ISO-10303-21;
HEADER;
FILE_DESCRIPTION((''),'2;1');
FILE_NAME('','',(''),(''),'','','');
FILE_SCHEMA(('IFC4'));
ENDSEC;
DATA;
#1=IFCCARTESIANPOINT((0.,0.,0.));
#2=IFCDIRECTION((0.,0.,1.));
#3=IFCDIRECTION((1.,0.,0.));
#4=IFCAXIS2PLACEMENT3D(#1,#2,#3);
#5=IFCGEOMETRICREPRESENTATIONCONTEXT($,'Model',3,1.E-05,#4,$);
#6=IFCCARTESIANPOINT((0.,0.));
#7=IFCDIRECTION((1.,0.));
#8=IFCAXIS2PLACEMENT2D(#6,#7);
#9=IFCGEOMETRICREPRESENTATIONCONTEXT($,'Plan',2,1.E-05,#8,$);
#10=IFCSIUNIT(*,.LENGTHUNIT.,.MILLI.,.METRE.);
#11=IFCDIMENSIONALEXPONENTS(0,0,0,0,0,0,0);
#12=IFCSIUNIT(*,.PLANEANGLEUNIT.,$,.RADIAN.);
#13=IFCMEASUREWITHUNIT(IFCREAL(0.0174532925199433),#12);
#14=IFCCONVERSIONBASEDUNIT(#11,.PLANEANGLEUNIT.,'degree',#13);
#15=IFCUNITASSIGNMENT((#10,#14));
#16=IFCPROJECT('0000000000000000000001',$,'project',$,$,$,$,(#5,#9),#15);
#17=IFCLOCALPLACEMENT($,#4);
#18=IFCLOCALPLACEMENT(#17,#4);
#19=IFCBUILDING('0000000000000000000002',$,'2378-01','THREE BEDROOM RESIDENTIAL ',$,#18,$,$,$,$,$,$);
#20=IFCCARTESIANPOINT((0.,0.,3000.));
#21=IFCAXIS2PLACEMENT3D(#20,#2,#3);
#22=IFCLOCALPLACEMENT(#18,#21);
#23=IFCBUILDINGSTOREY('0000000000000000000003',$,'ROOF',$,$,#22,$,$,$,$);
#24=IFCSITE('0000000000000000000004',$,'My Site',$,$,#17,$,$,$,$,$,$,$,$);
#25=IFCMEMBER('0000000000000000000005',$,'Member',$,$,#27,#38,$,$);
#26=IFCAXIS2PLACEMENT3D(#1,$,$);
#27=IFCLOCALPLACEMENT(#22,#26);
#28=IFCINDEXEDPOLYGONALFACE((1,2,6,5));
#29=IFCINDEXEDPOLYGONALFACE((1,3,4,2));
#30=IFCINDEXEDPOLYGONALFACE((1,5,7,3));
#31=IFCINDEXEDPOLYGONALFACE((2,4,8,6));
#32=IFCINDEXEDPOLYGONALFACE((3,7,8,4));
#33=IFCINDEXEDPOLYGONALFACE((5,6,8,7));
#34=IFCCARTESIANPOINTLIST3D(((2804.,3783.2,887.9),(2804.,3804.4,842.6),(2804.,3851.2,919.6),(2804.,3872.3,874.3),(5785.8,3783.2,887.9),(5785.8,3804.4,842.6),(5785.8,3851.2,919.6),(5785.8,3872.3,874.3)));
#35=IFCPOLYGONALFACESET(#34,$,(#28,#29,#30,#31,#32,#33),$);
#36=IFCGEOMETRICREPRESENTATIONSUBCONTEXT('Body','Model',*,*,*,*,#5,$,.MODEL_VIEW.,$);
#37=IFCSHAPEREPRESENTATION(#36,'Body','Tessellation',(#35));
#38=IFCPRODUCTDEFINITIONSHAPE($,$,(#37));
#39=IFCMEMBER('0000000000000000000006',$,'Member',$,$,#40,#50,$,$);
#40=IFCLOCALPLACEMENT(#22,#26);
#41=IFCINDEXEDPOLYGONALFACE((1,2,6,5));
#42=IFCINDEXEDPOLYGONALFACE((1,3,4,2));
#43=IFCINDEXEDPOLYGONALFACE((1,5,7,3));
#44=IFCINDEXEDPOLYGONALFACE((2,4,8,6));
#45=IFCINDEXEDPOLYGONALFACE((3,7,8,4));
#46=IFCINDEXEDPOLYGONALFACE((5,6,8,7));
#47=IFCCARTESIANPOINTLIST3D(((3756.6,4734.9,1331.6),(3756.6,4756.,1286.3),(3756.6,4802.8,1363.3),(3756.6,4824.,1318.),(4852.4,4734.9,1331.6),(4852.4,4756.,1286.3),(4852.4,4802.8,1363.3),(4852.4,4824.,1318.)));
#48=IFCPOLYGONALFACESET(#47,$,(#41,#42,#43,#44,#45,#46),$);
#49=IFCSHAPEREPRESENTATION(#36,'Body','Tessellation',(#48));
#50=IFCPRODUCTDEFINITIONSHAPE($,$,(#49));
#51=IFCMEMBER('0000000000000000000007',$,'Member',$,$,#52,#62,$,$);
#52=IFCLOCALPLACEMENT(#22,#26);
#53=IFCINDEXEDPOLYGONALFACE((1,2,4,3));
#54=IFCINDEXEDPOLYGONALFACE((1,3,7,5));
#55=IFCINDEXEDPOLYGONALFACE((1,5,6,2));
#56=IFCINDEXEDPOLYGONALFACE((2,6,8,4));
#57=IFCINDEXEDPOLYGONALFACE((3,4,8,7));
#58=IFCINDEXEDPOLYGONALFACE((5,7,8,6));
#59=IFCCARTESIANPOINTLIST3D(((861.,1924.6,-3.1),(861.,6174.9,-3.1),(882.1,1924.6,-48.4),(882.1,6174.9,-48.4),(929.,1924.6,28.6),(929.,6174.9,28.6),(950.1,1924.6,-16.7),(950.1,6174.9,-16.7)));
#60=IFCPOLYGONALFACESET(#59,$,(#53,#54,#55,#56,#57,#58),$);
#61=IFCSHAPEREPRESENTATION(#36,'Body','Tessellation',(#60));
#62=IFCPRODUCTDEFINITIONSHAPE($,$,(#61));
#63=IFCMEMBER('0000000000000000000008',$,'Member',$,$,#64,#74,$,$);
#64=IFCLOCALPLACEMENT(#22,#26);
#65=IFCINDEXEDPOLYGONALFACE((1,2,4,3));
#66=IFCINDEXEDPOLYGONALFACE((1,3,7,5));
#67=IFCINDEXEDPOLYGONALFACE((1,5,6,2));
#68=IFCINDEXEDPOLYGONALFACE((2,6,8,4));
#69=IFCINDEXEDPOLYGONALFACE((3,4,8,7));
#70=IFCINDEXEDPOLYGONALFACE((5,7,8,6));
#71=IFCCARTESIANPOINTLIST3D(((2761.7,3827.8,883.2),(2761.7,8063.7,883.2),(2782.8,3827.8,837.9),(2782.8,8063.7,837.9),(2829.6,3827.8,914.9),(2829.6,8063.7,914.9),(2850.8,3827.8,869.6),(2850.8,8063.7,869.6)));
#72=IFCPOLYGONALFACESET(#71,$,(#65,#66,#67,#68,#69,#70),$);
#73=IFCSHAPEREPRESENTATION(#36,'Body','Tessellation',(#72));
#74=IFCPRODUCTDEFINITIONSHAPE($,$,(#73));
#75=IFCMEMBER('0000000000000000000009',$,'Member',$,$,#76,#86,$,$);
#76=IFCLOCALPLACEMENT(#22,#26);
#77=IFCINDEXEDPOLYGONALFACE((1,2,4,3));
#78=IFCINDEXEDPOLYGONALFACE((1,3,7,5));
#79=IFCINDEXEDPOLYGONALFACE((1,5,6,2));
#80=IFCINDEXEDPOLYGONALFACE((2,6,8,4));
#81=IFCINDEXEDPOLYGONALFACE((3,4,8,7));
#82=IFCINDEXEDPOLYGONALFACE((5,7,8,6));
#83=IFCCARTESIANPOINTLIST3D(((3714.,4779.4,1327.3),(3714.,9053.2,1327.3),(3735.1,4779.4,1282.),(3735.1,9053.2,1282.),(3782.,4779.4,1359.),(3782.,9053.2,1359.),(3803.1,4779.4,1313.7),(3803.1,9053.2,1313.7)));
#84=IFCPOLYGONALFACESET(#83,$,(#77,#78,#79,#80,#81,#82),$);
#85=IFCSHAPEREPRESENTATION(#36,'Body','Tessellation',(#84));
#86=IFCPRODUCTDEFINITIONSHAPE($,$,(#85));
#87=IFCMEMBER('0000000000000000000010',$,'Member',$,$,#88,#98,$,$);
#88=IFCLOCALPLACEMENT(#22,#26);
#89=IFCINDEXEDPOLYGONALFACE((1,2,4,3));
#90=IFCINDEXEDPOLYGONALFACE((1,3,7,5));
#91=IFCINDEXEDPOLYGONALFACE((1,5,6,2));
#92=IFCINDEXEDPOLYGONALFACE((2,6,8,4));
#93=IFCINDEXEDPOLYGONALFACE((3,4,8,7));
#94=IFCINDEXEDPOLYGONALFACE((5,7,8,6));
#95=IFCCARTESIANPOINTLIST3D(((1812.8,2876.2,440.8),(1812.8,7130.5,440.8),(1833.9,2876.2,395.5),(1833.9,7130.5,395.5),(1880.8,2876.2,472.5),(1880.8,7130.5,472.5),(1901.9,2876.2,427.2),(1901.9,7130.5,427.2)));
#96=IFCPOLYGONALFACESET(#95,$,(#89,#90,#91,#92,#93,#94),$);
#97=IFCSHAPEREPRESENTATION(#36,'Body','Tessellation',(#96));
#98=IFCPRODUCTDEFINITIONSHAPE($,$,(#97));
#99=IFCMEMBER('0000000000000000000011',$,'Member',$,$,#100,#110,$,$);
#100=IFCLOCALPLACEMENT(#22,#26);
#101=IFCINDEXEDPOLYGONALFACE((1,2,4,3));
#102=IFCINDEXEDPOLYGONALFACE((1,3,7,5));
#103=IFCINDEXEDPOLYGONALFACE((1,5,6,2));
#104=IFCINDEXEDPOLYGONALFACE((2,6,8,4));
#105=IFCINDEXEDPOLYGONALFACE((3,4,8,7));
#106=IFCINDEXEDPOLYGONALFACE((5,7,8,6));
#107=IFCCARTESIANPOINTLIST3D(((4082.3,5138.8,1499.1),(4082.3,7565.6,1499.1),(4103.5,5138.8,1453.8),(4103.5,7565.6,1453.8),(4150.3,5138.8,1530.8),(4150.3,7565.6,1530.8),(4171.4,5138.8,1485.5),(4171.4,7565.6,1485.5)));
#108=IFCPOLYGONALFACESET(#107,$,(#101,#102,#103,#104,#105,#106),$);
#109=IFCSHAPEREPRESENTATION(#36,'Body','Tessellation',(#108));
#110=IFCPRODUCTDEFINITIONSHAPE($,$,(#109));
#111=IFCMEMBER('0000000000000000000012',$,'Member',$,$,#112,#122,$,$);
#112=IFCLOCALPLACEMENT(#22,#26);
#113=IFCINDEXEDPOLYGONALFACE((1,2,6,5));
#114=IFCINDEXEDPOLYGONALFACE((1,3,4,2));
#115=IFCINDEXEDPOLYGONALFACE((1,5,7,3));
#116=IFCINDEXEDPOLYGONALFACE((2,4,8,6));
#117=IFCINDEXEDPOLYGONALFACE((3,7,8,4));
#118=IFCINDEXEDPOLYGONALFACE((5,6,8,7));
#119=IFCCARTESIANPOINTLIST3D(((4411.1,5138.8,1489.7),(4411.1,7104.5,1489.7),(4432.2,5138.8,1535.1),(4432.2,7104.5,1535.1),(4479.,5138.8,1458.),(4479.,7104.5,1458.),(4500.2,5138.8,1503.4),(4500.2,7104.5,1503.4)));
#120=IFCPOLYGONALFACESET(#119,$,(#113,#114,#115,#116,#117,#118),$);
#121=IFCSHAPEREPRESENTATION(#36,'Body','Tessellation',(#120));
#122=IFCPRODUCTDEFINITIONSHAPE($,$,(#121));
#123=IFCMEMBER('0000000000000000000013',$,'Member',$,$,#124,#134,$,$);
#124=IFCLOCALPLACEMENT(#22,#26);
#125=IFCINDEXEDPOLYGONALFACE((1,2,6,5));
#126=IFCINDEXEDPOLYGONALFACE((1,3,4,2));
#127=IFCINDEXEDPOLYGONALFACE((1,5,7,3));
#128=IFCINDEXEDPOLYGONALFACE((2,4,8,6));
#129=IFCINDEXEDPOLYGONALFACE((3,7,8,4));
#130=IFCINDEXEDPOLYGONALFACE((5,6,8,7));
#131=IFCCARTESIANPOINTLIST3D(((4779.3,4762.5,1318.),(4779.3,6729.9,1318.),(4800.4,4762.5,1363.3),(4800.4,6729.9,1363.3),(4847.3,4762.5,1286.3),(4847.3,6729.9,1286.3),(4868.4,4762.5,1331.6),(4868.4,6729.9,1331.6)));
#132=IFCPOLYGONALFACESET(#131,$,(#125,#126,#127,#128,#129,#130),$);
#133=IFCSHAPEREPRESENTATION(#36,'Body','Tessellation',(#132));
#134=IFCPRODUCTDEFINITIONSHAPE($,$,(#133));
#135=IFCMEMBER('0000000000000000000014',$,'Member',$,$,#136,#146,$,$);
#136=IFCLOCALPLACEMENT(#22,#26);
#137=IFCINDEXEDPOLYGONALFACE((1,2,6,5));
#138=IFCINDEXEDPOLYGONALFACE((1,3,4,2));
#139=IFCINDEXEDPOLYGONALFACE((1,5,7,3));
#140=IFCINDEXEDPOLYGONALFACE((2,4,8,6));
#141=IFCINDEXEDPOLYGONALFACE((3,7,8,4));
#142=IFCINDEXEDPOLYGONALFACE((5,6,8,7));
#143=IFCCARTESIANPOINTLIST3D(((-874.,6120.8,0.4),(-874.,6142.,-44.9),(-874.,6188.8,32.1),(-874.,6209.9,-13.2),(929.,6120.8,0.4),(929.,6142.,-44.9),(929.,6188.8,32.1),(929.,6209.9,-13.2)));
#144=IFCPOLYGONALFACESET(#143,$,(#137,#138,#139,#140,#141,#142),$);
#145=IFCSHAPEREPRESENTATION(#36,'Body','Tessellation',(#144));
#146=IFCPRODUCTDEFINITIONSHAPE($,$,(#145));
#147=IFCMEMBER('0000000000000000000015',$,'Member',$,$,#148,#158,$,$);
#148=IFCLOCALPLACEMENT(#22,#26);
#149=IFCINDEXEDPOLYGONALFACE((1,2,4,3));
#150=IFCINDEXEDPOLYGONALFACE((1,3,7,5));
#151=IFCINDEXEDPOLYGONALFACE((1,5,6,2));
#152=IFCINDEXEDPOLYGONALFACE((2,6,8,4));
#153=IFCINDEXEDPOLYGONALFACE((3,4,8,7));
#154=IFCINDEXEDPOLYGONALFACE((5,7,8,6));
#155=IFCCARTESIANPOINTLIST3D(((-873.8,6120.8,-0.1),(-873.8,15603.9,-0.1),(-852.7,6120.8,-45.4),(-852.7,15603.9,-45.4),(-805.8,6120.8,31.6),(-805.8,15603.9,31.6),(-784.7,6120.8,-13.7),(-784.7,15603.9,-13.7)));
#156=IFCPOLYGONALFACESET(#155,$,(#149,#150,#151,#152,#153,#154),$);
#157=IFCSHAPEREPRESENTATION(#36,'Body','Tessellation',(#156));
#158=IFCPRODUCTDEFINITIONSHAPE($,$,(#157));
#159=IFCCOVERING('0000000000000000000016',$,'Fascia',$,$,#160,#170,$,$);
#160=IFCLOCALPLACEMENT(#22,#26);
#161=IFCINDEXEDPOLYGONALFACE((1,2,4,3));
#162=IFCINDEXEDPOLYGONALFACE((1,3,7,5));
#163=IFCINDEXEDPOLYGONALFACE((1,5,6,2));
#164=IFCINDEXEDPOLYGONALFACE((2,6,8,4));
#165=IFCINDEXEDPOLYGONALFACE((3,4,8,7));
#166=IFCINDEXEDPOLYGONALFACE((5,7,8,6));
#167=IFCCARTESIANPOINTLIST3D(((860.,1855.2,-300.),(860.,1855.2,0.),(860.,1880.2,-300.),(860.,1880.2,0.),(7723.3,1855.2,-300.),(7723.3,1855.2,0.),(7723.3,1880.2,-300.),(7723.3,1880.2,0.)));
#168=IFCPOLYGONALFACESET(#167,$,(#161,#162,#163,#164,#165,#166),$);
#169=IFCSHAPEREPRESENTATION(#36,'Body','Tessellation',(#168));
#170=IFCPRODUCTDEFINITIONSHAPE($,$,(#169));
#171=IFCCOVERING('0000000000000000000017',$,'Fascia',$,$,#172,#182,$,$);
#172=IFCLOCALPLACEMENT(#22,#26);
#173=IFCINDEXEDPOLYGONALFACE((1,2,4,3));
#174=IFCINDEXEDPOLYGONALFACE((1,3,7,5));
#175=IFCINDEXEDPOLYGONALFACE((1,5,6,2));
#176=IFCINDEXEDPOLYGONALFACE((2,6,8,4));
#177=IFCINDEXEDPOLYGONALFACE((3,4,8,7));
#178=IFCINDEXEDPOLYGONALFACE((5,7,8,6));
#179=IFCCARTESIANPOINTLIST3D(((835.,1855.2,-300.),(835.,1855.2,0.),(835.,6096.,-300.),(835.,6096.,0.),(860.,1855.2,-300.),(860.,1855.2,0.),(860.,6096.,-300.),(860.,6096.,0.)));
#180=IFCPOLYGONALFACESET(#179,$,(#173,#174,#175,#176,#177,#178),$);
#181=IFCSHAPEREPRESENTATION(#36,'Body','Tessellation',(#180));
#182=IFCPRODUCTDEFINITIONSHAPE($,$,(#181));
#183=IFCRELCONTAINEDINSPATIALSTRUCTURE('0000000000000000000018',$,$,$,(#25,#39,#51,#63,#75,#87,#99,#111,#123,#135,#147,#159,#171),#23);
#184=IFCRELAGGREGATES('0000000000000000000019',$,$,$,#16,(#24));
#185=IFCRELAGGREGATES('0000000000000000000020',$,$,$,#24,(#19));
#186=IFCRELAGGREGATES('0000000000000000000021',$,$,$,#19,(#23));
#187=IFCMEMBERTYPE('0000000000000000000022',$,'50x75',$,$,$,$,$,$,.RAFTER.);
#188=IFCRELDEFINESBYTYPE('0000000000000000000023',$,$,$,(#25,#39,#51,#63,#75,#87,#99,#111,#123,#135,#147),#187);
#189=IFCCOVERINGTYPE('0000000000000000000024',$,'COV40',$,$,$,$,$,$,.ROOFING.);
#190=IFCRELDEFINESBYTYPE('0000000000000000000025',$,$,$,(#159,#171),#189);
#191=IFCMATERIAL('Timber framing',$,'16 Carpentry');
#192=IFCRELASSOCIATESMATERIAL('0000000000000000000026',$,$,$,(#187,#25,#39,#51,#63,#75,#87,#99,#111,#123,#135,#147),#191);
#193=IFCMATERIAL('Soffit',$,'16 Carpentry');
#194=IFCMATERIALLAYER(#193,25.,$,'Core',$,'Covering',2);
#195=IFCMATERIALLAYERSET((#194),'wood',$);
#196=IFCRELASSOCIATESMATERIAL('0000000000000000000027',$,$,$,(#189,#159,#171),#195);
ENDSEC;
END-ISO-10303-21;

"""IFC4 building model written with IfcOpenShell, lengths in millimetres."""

from ifc_helpers import new_model, entity, si_unit, converted_unit, frame, origin_with_axes, origin_2d_with_axis, place, context, subcontext, project, spatial, indexed_curve, rectangle, outline, extrude, material, layer, layer_set, layer_usage, material_profile, profile_set, profile_usage, type_object, element, save


model = new_model("IFC4")

# Units and contexts
model_context = context("Model", 3, precision=1e-05, world=origin_with_axes())
plan_context = context("Plan", 2, precision=1e-05, world=origin_2d_with_axis())
body_context = subcontext(model_context, "Body", "Model", "MODEL_VIEW")
ifc_project = project(units=[si_unit("LENGTHUNIT", "METRE", prefix="MILLI"), converted_unit("PLANEANGLEUNIT", "degree", entity("IfcReal", 0.0174532925199433), si_unit("PLANEANGLEUNIT", "RADIAN"), dimensions=[0, 0, 0, 0, 0, 0, 0])], contexts=[model_context, plan_context])

# Site, building, storey
site_placement = place(None, origin_with_axes())
site = spatial("IfcSite", under=ifc_project, at=site_placement, Name="My Site")
building_placement = place(site_placement, origin_with_axes())
building = spatial("IfcBuilding", under=site, at=building_placement, Name="2378-01", Description="THREE BEDROOM RESIDENTIAL ")
storey_placement = place(building_placement, frame((0.0, 0.0, 3000.0), z_axis=(0.0, 0.0, 1.0), x_axis=(1.0, 0.0, 0.0)))
storey = spatial("IfcBuildingStorey", under=building, at=storey_placement, Name="ROOF")

# Members
ifc_material_1 = material(Name="Timber framing", Category="16 Carpentry")
ifc_material_profile_1 = material_profile(ifc_material_1, rectangle(XDim=50.0, YDim=75.0), Name="Lumber2", Category="Substrate", Priority=2)
ifc_profile_set_1 = profile_set([ifc_material_profile_1])
member_type_1 = type_object("IfcMemberType", Name="50x75", PredefinedType="RAFTER", material=ifc_profile_set_1)
ifc_profile_usage_1 = profile_usage(ifc_profile_set_1, cardinal=5)
member_1_placement = place(storey_placement, frame((2804.0, 3827.8, 881.1), z_axis=(1.0, 0.0, 0.0), x_axis=(0.0, 0.422618, -0.906308)))
element("IfcMember", 1, at=member_1_placement, inside=storey, type_object=member_type_1, material=ifc_profile_usage_1, Name="Member", context=body_context, shape_type="SweptSolid", body=[
    extrude(rectangle(XDim=50.0, YDim=75.0), origin_with_axes(), (0.0, 0.0, 1.0), 2981.8),
])
ifc_profile_usage_2 = profile_usage(ifc_profile_set_1, cardinal=5)
member_2_placement = place(storey_placement, frame((3756.6, 4779.4, 1324.8), z_axis=(1.0, 0.0, 0.0), x_axis=(0.0, 0.422618, -0.906308)))
element("IfcMember", 2, at=member_2_placement, inside=storey, type_object=member_type_1, material=ifc_profile_usage_2, Name="Member", context=body_context, shape_type="SweptSolid", body=[
    extrude(rectangle(XDim=50.0, YDim=75.0), origin_with_axes(), (0.0, 0.0, 1.0), 1095.8),
])
ifc_profile_usage_3 = profile_usage(ifc_profile_set_1, cardinal=5)
member_3_placement = place(storey_placement, frame((905.6, 1924.6, -9.9), z_axis=(0.0, 1.0, 0.0), x_axis=(-0.422618, 0.0, 0.906308)))
element("IfcMember", 3, at=member_3_placement, inside=storey, type_object=member_type_1, material=ifc_profile_usage_3, Name="Member", context=body_context, shape_type="SweptSolid", body=[
    extrude(rectangle(XDim=50.0, YDim=75.0), origin_with_axes(), (0.0, 0.0, 1.0), 4250.4),
])
ifc_profile_usage_4 = profile_usage(ifc_profile_set_1, cardinal=5)
member_4_placement = place(storey_placement, frame((2806.2, 3827.8, 876.4), z_axis=(0.0, 1.0, 0.0), x_axis=(-0.422618, 0.0, 0.906308)))
element("IfcMember", 4, at=member_4_placement, inside=storey, type_object=member_type_1, material=ifc_profile_usage_4, Name="Member", context=body_context, shape_type="SweptSolid", body=[
    extrude(rectangle(XDim=50.0, YDim=75.0), origin_with_axes(), (0.0, 0.0, 1.0), 4235.9),
])
ifc_profile_usage_5 = profile_usage(ifc_profile_set_1, cardinal=5)
member_5_placement = place(storey_placement, frame((3758.6, 4779.4, 1320.5), z_axis=(0.0, 1.0, 0.0), x_axis=(-0.422618, 0.0, 0.906308)))
element("IfcMember", 5, at=member_5_placement, inside=storey, type_object=member_type_1, material=ifc_profile_usage_5, Name="Member", context=body_context, shape_type="SweptSolid", body=[
    extrude(rectangle(XDim=50.0, YDim=75.0), origin_with_axes(), (0.0, 0.0, 1.0), 4273.8),
])
ifc_profile_usage_6 = profile_usage(ifc_profile_set_1, cardinal=5)
member_6_placement = place(storey_placement, frame((1857.4, 2876.2, 434.0), z_axis=(0.0, 1.0, 0.0), x_axis=(-0.422618, 0.0, 0.906308)))
element("IfcMember", 6, at=member_6_placement, inside=storey, type_object=member_type_1, material=ifc_profile_usage_6, Name="Member", context=body_context, shape_type="SweptSolid", body=[
    extrude(rectangle(XDim=50.0, YDim=75.0), origin_with_axes(), (0.0, 0.0, 1.0), 4254.3),
])
ifc_profile_usage_7 = profile_usage(ifc_profile_set_1, cardinal=5)
member_7_placement = place(storey_placement, frame((4126.9, 5138.8, 1492.3), z_axis=(0.0, 1.0, 0.0), x_axis=(-0.422618, 0.0, 0.906308)))
element("IfcMember", 7, at=member_7_placement, inside=storey, type_object=member_type_1, material=ifc_profile_usage_7, Name="Member", context=body_context, shape_type="SweptSolid", body=[
    extrude(rectangle(XDim=50.0, YDim=75.0), origin_with_axes(), (0.0, 0.0, 1.0), 2426.8),
])
ifc_profile_usage_8 = profile_usage(ifc_profile_set_1, cardinal=5)
member_8_placement = place(storey_placement, frame((4455.6, 5138.8, 1496.5), z_axis=(0.0, 1.0, 0.0), x_axis=(-0.422618, 0.0, -0.906308)))
element("IfcMember", 8, at=member_8_placement, inside=storey, type_object=member_type_1, material=ifc_profile_usage_8, Name="Member", context=body_context, shape_type="SweptSolid", body=[
    extrude(rectangle(XDim=50.0, YDim=75.0), origin_with_axes(), (0.0, 0.0, 1.0), 1965.7),
])
ifc_profile_usage_9 = profile_usage(ifc_profile_set_1, cardinal=5)
member_9_placement = place(storey_placement, frame((4823.8, 4762.5, 1324.8), z_axis=(0.0, 1.0, 0.0), x_axis=(-0.422618, 0.0, -0.906308)))
element("IfcMember", 9, at=member_9_placement, inside=storey, type_object=member_type_1, material=ifc_profile_usage_9, Name="Member", context=body_context, shape_type="SweptSolid", body=[
    extrude(rectangle(XDim=50.0, YDim=75.0), origin_with_axes(), (0.0, 0.0, 1.0), 1967.5),
])
ifc_profile_usage_10 = profile_usage(ifc_profile_set_1, cardinal=5)
member_10_placement = place(storey_placement, frame((929.0, 6165.4, -6.4), z_axis=(-1.0, 0.0, 0.0), x_axis=(0.0, -0.422618, 0.906308)))
element("IfcMember", 10, at=member_10_placement, inside=storey, type_object=member_type_1, material=ifc_profile_usage_10, Name="Member", context=body_context, shape_type="SweptSolid", body=[
    extrude(rectangle(XDim=50.0, YDim=75.0), origin_with_axes(), (0.0, 0.0, 1.0), 1803.0),
])
ifc_profile_usage_11 = profile_usage(ifc_profile_set_1, cardinal=5)
member_11_placement = place(storey_placement, frame((-829.2, 6120.8, -6.9), z_axis=(0.0, 1.0, 0.0), x_axis=(-0.422618, 0.0, 0.906308)))
element("IfcMember", 11, at=member_11_placement, inside=storey, type_object=member_type_1, material=ifc_profile_usage_11, Name="Member", context=body_context, shape_type="SweptSolid", body=[
    extrude(rectangle(XDim=50.0, YDim=75.0), origin_with_axes(), (0.0, 0.0, 1.0), 9483.1),
])

# Coverings
ifc_material_2 = material(Name="Soffit", Category="16 Carpentry")
ifc_layer = layer(ifc_material_2, 25.0, Name="Core", Category="Covering", Priority=2)
ifc_layer_set = layer_set([ifc_layer], Name="wood")
ifc_layer_usage_1 = layer_usage(ifc_layer_set, "AXIS2", "POSITIVE", 0.0)
covering_type = type_object("IfcCoveringType", Name="COV40", PredefinedType="ROOFING", material=ifc_layer_set)
covering_1_placement = place(storey_placement, frame((860.0, 1855.2, -300.0), z_axis=(0.0, 0.0, 1.0), x_axis=(1.0, 0.0, 0.0)))
element("IfcCovering", 12, at=covering_1_placement, inside=storey, type_object=covering_type, material=ifc_layer_usage_1, Name="Fascia", context=body_context, shape_type="SweptSolid", body=[
    extrude(outline(indexed_curve([(0.0, 0.0), (0.0, 25.0), (6863.3, 25.0), (6863.3, 0.0), (0.0, 0.0)], self_intersect=False)), origin_with_axes(), (0.0, 0.0, 1.0), 300.0),
])
ifc_layer_usage_2 = layer_usage(ifc_layer_set, "AXIS2", "POSITIVE", 0.0)
covering_2_placement = place(storey_placement, frame((835.0, 6096.0, -300.0), z_axis=(0.0, 0.0, 1.0), x_axis=(0.0, -1.0, 0.0)))
element("IfcCovering", 13, at=covering_2_placement, inside=storey, type_object=covering_type, material=ifc_layer_usage_2, Name="Fascia", context=body_context, shape_type="SweptSolid", body=[
    extrude(outline(indexed_curve([(0.0, 0.0), (0.0, 25.0), (4240.8, 25.0), (4240.8, 0.0), (0.0, 0.0)], self_intersect=False)), origin_with_axes(), (0.0, 0.0, 1.0), 300.0),
])

save(model, "model.ifc")
